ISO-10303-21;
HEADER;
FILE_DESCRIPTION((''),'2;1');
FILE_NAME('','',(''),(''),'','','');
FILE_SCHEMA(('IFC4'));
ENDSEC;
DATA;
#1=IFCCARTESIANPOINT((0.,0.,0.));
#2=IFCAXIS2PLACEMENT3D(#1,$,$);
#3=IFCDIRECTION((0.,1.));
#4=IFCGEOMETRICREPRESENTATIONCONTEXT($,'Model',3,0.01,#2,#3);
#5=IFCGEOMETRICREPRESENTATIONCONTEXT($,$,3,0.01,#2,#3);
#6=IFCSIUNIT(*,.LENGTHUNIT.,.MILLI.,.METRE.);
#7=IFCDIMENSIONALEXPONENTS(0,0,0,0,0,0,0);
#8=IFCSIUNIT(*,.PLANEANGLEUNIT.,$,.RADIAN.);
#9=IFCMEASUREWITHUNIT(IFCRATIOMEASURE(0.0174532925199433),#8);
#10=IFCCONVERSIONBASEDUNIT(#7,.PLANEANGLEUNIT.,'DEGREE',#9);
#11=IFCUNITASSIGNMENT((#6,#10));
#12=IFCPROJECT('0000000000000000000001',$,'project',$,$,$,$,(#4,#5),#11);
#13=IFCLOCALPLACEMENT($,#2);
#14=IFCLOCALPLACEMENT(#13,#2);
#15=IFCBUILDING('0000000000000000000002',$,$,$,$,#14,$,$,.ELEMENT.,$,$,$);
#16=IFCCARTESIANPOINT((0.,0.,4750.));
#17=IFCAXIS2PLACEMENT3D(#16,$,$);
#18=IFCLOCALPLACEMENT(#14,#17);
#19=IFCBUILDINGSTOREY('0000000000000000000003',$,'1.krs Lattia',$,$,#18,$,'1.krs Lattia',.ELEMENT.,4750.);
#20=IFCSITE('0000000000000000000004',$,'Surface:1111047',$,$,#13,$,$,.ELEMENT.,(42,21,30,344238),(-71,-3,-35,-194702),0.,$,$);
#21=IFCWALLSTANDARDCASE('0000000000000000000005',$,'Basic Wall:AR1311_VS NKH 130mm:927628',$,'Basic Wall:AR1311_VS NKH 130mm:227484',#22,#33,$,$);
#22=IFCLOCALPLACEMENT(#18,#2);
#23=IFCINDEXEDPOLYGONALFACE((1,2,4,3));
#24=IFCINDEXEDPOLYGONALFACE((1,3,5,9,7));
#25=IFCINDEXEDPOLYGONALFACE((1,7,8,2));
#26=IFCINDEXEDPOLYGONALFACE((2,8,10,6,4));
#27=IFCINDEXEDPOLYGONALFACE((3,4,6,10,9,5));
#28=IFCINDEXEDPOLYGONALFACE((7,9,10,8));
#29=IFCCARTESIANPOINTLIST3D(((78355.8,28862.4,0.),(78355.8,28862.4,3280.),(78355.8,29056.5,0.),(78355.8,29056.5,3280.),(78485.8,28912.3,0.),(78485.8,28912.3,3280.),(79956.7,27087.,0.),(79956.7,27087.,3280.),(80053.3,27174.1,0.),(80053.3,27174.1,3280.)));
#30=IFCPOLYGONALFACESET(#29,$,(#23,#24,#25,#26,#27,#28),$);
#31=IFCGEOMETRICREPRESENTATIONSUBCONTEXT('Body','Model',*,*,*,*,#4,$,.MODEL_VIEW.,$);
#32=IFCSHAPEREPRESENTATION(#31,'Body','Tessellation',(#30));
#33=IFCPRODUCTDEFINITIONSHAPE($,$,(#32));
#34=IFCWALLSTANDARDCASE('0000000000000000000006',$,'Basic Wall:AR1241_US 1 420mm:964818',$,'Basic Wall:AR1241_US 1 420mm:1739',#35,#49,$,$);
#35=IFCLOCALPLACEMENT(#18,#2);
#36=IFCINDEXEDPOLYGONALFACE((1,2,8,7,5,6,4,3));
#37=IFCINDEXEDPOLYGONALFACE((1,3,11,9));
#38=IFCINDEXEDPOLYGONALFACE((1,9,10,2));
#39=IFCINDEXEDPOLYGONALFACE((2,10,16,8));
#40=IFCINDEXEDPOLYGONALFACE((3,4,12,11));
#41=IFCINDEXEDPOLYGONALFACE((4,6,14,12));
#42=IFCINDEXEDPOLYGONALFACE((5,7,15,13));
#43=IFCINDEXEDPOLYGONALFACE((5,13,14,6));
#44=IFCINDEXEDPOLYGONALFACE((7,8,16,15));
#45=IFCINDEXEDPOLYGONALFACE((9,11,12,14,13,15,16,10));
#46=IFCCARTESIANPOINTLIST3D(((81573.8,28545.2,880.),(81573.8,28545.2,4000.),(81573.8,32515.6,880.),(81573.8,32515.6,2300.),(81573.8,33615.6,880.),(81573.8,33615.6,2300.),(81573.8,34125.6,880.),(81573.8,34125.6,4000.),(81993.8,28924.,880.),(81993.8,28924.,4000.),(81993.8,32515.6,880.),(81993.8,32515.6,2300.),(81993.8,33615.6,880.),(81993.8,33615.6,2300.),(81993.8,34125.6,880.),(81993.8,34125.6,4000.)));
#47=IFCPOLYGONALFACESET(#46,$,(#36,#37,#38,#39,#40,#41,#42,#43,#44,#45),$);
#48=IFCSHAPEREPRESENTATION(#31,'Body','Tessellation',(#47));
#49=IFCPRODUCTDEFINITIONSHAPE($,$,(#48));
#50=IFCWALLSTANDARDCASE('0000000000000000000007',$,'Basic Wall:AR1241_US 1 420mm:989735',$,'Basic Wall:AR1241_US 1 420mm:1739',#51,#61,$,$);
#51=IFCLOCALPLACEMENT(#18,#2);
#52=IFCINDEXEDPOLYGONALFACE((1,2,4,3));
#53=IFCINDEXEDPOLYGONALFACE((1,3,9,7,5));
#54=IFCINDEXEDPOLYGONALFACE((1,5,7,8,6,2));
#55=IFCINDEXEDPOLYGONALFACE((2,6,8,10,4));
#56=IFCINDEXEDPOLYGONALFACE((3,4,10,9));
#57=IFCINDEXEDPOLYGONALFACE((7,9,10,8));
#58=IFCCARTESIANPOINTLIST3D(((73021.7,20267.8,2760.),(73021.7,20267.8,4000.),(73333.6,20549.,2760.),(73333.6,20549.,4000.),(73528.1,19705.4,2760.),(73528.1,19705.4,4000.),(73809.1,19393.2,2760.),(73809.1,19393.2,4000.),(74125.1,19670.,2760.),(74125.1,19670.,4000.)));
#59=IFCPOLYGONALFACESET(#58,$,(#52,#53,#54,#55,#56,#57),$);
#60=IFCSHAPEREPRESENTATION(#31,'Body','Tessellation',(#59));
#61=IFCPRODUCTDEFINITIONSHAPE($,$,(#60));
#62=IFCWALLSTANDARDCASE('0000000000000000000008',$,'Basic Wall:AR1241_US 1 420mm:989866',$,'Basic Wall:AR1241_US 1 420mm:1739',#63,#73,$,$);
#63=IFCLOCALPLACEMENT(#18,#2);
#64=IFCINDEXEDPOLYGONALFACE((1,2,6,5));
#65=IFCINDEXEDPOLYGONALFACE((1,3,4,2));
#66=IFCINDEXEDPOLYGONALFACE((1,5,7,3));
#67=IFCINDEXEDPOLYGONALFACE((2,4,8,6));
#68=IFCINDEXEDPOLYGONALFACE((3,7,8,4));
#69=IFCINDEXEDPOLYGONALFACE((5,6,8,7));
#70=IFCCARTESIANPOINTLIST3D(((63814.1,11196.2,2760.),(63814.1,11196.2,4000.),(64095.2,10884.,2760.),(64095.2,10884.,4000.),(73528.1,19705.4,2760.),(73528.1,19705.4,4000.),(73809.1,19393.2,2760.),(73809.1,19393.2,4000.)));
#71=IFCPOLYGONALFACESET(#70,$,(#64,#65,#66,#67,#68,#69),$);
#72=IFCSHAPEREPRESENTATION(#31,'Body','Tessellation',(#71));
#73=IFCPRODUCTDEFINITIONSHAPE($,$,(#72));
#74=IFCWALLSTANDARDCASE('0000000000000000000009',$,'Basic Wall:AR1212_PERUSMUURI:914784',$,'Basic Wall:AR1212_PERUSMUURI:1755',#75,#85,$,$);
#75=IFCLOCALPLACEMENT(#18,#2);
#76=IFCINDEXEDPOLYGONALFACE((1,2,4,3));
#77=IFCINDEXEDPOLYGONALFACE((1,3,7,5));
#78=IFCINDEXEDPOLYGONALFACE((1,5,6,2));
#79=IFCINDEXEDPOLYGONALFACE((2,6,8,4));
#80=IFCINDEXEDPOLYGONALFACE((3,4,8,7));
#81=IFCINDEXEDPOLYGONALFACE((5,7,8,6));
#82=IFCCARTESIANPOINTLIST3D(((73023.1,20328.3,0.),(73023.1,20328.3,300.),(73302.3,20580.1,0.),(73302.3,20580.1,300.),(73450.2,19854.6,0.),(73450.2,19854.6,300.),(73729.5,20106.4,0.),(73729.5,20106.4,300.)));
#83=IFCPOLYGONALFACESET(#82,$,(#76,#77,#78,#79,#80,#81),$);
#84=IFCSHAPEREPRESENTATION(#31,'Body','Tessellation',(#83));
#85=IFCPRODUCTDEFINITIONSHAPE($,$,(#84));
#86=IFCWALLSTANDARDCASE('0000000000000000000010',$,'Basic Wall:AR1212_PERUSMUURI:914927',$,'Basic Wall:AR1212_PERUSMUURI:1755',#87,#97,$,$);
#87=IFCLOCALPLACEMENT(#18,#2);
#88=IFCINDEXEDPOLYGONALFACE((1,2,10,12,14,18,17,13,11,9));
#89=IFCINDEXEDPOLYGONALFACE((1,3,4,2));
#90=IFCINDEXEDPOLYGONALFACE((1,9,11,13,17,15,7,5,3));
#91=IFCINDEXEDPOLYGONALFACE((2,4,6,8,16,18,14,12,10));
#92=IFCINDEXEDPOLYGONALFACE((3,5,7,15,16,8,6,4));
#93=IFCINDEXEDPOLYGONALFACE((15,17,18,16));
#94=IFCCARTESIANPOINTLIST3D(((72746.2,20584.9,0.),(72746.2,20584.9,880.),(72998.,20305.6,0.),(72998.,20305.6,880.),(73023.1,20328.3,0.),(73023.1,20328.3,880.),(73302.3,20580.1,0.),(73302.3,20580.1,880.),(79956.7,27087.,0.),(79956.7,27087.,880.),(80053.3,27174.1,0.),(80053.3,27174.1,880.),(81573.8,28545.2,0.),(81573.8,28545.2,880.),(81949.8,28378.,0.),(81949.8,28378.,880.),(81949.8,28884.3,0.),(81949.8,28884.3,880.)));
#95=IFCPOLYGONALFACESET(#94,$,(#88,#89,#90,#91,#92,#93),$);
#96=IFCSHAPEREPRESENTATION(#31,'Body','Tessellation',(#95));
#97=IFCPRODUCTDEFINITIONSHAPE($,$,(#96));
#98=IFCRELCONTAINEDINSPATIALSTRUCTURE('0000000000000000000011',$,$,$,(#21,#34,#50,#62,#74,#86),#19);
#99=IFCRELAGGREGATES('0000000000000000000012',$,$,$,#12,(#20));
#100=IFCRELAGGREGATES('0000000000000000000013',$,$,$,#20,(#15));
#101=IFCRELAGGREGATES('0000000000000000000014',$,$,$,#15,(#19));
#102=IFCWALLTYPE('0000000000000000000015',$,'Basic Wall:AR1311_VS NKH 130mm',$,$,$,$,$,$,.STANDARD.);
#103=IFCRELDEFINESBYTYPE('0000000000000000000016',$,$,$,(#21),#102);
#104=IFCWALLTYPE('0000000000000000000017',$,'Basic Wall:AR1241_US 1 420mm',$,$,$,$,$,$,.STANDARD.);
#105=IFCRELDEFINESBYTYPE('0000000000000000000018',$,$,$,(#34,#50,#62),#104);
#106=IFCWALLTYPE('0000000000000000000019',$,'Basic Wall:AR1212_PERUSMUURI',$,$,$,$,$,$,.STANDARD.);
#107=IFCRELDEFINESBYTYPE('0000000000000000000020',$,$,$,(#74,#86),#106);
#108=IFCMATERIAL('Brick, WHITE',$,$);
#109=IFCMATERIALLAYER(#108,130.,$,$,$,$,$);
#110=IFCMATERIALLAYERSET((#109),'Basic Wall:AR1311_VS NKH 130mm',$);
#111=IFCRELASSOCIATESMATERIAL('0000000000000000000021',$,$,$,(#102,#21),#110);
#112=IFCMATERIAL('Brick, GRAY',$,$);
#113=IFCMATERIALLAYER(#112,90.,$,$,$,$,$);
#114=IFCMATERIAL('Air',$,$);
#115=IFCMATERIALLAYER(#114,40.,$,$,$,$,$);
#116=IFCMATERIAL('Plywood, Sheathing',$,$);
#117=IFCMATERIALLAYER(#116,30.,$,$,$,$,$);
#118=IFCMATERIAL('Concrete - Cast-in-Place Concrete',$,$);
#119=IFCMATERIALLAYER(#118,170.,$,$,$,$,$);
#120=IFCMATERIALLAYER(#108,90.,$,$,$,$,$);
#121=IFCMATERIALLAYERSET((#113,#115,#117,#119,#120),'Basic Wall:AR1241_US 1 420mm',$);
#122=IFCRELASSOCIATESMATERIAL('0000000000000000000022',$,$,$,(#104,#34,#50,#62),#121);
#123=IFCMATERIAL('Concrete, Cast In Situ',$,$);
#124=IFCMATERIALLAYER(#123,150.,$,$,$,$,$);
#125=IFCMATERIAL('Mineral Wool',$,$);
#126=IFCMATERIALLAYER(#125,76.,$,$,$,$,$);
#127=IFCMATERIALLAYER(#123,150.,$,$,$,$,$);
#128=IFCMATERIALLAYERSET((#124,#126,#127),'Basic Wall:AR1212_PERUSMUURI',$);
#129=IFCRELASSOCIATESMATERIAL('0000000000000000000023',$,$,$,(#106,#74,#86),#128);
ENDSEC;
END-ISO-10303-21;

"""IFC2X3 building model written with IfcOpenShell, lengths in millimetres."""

from ifc_helpers import new_model, entity, si_unit, converted_unit, direction, frame, frame_2d, origin, place, context, subcontext, project, spatial, polyline, rectangle, outline, extrude, material, layer, layer_set, layer_usage, type_object, element, save


model = new_model("IFC2X3")

# Units and contexts
model_context = context("Model", 3, precision=0.01, world=origin(), true_north=direction((0.0, 1.0)))
context_of_model = context(None, 3, precision=0.01, world=origin(), true_north=direction((0.0, 1.0)))
body_context = subcontext(model_context, "Body", "Model", "MODEL_VIEW")
ifc_project = project(units=[si_unit("LENGTHUNIT", "METRE", prefix="MILLI"), converted_unit("PLANEANGLEUNIT", "DEGREE", entity("IfcRatioMeasure", 0.0174532925199433), si_unit("PLANEANGLEUNIT", "RADIAN"), dimensions=[0, 0, 0, 0, 0, 0, 0])], contexts=[model_context, context_of_model])

# Site, building, storey
site_placement = place(None, origin())
site = spatial("IfcSite", under=ifc_project, at=site_placement, Name="Surface:1111047", CompositionType="ELEMENT", RefLatitude=(42, 21, 30, 344238), RefLongitude=(-71, -3, -35, -194702), RefElevation=0.0)
building_placement = place(site_placement, origin())
building = spatial("IfcBuilding", under=site, at=building_placement, CompositionType="ELEMENT")
storey_placement = place(building_placement, frame((0.0, 0.0, 4750.0)))
storey = spatial("IfcBuildingStorey", under=building, at=storey_placement, Name="1.krs Lattia", LongName="1.krs Lattia", CompositionType="ELEMENT", Elevation=4750.0)

# Wall
ifc_material_1 = material(Name="Brick, WHITE")
ifc_layer_1 = layer(ifc_material_1, 130.0)
ifc_layer_set_1 = layer_set([ifc_layer_1], Name="Basic Wall:AR1311_VS NKH 130mm")
ifc_layer_usage_1 = layer_usage(ifc_layer_set_1, "AXIS2", "NEGATIVE", 65.0)
wall_type_1 = type_object("IfcWallType", Name="Basic Wall:AR1311_VS NKH 130mm", PredefinedType="STANDARD", material=ifc_layer_set_1)
wall_1_placement = place(storey_placement, frame((80005.0, 27130.6, 0.0), z_axis=(0.0, 0.0, 1.0), x_axis=(-0.669684, 0.742646, 0.0)))
element("IfcWallStandardCase", 1, at=wall_1_placement, inside=storey, type_object=wall_type_1, material=ifc_layer_usage_1, Name="Basic Wall:AR1311_VS NKH 130mm:927628", ObjectType="Basic Wall:AR1311_VS NKH 130mm:227484", context=body_context, shape_type="SweptSolid", body=[
    extrude(outline(polyline([(2534.7, -65.0), (2390.6, 65.0), (0.0, 65.0), (0.0, -65.0), (2340.6, -65.0), (2534.7, -65.0)])), origin(), (0.0, 0.0, 1.0), 3280.0),
])

# Shared definitions
ifc_material_2 = material(Name="Brick, GRAY")
ifc_layer_2 = layer(ifc_material_2, 90.0)
ifc_material_3 = material(Name="Air")
ifc_layer_3 = layer(ifc_material_3, 40.0)
ifc_material_4 = material(Name="Plywood, Sheathing")
ifc_layer_4 = layer(ifc_material_4, 30.0)
ifc_material_5 = material(Name="Concrete - Cast-in-Place Concrete")
ifc_layer_5 = layer(ifc_material_5, 170.0)
ifc_layer_6 = layer(ifc_material_1, 90.0)
ifc_layer_set_2 = layer_set([ifc_layer_2, ifc_layer_3, ifc_layer_4, ifc_layer_5, ifc_layer_6], Name="Basic Wall:AR1241_US 1 420mm")
wall_type_2 = type_object("IfcWallType", Name="Basic Wall:AR1241_US 1 420mm", PredefinedType="STANDARD", material=ifc_layer_set_2)

# Wall, opening
ifc_layer_usage_2 = layer_usage(ifc_layer_set_2, "AXIS2", "NEGATIVE", 210.0)
wall_2_placement = place(storey_placement, frame((81783.8, 28545.2, 880.0), z_axis=(0.0, 0.0, 1.0), x_axis=(0.0, 1.0, 0.0)))
wall_2 = element("IfcWallStandardCase", 2, at=wall_2_placement, inside=storey, type_object=wall_type_2, material=ifc_layer_usage_2, Name="Basic Wall:AR1241_US 1 420mm:964818", ObjectType="Basic Wall:AR1241_US 1 420mm:1739", context=body_context, shape_type="SweptSolid", body=[
    extrude(outline(polyline([(378.7, -210.0), (5160.4, -210.0), (5580.4, -210.0), (5580.4, 210.0), (0.0, 210.0), (378.7, -210.0)])), origin(), (0.0, 0.0, 1.0), 3120.0),
])
opening_1_placement = place(wall_2_placement, frame((5070.4, 210.0, -880.0)))
element("IfcOpeningElement", 3, at=opening_1_placement, cuts=wall_2, ObjectType="Opening", context=body_context, shape_type="SweptSolid", body=[
    extrude(rectangle(XDim=2300.0, YDim=1100.0, at=frame_2d((1150.0, 550.0), x_axis=(1.0, 0.0))), frame((0.0, 0.0, 0.0), z_axis=(0.0, -1.0, 0.0), x_axis=(0.0, 0.0, 1.0)), (0.0, 0.0, 1.0), 420.0),
])

# Walls
ifc_layer_usage_3 = layer_usage(ifc_layer_set_2, "AXIS2", "NEGATIVE", 210.0)
wall_3_placement = place(storey_placement, frame((73177.5, 20408.5, 2760.0), z_axis=(0.0, 0.0, 1.0), x_axis=(0.669131, -0.743145, 0.0)))
element("IfcWallStandardCase", 4, at=wall_3_placement, inside=storey, type_object=wall_type_2, material=ifc_layer_usage_3, Name="Basic Wall:AR1241_US 1 420mm:989735", ObjectType="Basic Wall:AR1241_US 1 420mm:1739", context=body_context, shape_type="SweptSolid", body=[
    extrude(outline(polyline([(1177.1, -210.0), (1182.9, 210.0), (0.0, 210.0), (0.3, -210.0), (757.1, -210.0), (1177.1, -210.0)])), origin(), (0.0, 0.0, 1.0), 1240.0),
])
ifc_layer_usage_4 = layer_usage(ifc_layer_set_2, "AXIS2", "NEGATIVE", 210.0)
wall_4_placement = place(storey_placement, frame((73670.8, 19551.2, 2760.0), z_axis=(0.0, 0.0, 1.0), x_axis=(-0.752213, -0.65892, 0.0)))
element("IfcWallStandardCase", 5, at=wall_4_placement, inside=storey, type_object=wall_type_2, material=ifc_layer_usage_4, Name="Basic Wall:AR1241_US 1 420mm:989866", ObjectType="Basic Wall:AR1241_US 1 420mm:1739", context=body_context, shape_type="SweptSolid", body=[
    extrude(outline(polyline([(12919.5, -210.0), (12913.8, 210.0), (0.0, 210.0), (5.7, -210.0), (12919.5, -210.0)])), origin(), (0.0, 0.0, 1.0), 1240.0),
])
ifc_material_6 = material(Name="Concrete, Cast In Situ")
ifc_layer_7 = layer(ifc_material_6, 150.0)
ifc_material_7 = material(Name="Mineral Wool")
ifc_layer_8 = layer(ifc_material_7, 76.0)
ifc_layer_9 = layer(ifc_material_6, 150.0)
ifc_layer_set_3 = layer_set([ifc_layer_7, ifc_layer_8, ifc_layer_9], Name="Basic Wall:AR1212_PERUSMUURI")
ifc_layer_usage_5 = layer_usage(ifc_layer_set_3, "AXIS2", "NEGATIVE", 188.0)
wall_type_3 = type_object("IfcWallType", Name="Basic Wall:AR1212_PERUSMUURI", PredefinedType="STANDARD", material=ifc_layer_set_3)
wall_5_placement = place(storey_placement, frame((73589.8, 19980.5, 0.0), z_axis=(0.0, 0.0, 1.0), x_axis=(-0.669684, 0.742646, 0.0)))
element("IfcWallStandardCase", 6, at=wall_5_placement, inside=storey, type_object=wall_type_3, material=ifc_layer_usage_5, Name="Basic Wall:AR1212_PERUSMUURI:914784", ObjectType="Basic Wall:AR1212_PERUSMUURI:1755", context=body_context, shape_type="SweptSolid", body=[
    extrude(rectangle(XDim=637.8, YDim=376.0, at=frame_2d((318.9, 0.0), x_axis=(-1.0, 0.0))), origin(), (0.0, 0.0, 1.0), 300.0),
])
ifc_layer_usage_6 = layer_usage(ifc_layer_set_3, "AXIS2", "NEGATIVE", 188.0)
wall_6_placement = place(storey_placement, frame((72872.1, 20445.2, 0.0), z_axis=(0.0, 0.0, 1.0), x_axis=(0.742646, 0.669684, 0.0)))
element("IfcWallStandardCase", 7, at=wall_6_placement, inside=storey, type_object=wall_type_3, material=ifc_layer_usage_6, Name="Basic Wall:AR1212_PERUSMUURI:914927", ObjectType="Basic Wall:AR1212_PERUSMUURI:1755", context=body_context, shape_type="SweptSolid", body=[
    extrude(outline(polyline([(12054.0, -188.0), (12393.1, 188.0), (11886.8, 188.0), (9839.3, 188.0), (9709.3, 188.0), (0.0, 188.0), (0.0, -188.0), (33.8, -188.0), (409.8, -188.0), (12054.0, -188.0)])), origin(), (0.0, 0.0, 1.0), 880.0),
])

save(model, "model.ifc")
